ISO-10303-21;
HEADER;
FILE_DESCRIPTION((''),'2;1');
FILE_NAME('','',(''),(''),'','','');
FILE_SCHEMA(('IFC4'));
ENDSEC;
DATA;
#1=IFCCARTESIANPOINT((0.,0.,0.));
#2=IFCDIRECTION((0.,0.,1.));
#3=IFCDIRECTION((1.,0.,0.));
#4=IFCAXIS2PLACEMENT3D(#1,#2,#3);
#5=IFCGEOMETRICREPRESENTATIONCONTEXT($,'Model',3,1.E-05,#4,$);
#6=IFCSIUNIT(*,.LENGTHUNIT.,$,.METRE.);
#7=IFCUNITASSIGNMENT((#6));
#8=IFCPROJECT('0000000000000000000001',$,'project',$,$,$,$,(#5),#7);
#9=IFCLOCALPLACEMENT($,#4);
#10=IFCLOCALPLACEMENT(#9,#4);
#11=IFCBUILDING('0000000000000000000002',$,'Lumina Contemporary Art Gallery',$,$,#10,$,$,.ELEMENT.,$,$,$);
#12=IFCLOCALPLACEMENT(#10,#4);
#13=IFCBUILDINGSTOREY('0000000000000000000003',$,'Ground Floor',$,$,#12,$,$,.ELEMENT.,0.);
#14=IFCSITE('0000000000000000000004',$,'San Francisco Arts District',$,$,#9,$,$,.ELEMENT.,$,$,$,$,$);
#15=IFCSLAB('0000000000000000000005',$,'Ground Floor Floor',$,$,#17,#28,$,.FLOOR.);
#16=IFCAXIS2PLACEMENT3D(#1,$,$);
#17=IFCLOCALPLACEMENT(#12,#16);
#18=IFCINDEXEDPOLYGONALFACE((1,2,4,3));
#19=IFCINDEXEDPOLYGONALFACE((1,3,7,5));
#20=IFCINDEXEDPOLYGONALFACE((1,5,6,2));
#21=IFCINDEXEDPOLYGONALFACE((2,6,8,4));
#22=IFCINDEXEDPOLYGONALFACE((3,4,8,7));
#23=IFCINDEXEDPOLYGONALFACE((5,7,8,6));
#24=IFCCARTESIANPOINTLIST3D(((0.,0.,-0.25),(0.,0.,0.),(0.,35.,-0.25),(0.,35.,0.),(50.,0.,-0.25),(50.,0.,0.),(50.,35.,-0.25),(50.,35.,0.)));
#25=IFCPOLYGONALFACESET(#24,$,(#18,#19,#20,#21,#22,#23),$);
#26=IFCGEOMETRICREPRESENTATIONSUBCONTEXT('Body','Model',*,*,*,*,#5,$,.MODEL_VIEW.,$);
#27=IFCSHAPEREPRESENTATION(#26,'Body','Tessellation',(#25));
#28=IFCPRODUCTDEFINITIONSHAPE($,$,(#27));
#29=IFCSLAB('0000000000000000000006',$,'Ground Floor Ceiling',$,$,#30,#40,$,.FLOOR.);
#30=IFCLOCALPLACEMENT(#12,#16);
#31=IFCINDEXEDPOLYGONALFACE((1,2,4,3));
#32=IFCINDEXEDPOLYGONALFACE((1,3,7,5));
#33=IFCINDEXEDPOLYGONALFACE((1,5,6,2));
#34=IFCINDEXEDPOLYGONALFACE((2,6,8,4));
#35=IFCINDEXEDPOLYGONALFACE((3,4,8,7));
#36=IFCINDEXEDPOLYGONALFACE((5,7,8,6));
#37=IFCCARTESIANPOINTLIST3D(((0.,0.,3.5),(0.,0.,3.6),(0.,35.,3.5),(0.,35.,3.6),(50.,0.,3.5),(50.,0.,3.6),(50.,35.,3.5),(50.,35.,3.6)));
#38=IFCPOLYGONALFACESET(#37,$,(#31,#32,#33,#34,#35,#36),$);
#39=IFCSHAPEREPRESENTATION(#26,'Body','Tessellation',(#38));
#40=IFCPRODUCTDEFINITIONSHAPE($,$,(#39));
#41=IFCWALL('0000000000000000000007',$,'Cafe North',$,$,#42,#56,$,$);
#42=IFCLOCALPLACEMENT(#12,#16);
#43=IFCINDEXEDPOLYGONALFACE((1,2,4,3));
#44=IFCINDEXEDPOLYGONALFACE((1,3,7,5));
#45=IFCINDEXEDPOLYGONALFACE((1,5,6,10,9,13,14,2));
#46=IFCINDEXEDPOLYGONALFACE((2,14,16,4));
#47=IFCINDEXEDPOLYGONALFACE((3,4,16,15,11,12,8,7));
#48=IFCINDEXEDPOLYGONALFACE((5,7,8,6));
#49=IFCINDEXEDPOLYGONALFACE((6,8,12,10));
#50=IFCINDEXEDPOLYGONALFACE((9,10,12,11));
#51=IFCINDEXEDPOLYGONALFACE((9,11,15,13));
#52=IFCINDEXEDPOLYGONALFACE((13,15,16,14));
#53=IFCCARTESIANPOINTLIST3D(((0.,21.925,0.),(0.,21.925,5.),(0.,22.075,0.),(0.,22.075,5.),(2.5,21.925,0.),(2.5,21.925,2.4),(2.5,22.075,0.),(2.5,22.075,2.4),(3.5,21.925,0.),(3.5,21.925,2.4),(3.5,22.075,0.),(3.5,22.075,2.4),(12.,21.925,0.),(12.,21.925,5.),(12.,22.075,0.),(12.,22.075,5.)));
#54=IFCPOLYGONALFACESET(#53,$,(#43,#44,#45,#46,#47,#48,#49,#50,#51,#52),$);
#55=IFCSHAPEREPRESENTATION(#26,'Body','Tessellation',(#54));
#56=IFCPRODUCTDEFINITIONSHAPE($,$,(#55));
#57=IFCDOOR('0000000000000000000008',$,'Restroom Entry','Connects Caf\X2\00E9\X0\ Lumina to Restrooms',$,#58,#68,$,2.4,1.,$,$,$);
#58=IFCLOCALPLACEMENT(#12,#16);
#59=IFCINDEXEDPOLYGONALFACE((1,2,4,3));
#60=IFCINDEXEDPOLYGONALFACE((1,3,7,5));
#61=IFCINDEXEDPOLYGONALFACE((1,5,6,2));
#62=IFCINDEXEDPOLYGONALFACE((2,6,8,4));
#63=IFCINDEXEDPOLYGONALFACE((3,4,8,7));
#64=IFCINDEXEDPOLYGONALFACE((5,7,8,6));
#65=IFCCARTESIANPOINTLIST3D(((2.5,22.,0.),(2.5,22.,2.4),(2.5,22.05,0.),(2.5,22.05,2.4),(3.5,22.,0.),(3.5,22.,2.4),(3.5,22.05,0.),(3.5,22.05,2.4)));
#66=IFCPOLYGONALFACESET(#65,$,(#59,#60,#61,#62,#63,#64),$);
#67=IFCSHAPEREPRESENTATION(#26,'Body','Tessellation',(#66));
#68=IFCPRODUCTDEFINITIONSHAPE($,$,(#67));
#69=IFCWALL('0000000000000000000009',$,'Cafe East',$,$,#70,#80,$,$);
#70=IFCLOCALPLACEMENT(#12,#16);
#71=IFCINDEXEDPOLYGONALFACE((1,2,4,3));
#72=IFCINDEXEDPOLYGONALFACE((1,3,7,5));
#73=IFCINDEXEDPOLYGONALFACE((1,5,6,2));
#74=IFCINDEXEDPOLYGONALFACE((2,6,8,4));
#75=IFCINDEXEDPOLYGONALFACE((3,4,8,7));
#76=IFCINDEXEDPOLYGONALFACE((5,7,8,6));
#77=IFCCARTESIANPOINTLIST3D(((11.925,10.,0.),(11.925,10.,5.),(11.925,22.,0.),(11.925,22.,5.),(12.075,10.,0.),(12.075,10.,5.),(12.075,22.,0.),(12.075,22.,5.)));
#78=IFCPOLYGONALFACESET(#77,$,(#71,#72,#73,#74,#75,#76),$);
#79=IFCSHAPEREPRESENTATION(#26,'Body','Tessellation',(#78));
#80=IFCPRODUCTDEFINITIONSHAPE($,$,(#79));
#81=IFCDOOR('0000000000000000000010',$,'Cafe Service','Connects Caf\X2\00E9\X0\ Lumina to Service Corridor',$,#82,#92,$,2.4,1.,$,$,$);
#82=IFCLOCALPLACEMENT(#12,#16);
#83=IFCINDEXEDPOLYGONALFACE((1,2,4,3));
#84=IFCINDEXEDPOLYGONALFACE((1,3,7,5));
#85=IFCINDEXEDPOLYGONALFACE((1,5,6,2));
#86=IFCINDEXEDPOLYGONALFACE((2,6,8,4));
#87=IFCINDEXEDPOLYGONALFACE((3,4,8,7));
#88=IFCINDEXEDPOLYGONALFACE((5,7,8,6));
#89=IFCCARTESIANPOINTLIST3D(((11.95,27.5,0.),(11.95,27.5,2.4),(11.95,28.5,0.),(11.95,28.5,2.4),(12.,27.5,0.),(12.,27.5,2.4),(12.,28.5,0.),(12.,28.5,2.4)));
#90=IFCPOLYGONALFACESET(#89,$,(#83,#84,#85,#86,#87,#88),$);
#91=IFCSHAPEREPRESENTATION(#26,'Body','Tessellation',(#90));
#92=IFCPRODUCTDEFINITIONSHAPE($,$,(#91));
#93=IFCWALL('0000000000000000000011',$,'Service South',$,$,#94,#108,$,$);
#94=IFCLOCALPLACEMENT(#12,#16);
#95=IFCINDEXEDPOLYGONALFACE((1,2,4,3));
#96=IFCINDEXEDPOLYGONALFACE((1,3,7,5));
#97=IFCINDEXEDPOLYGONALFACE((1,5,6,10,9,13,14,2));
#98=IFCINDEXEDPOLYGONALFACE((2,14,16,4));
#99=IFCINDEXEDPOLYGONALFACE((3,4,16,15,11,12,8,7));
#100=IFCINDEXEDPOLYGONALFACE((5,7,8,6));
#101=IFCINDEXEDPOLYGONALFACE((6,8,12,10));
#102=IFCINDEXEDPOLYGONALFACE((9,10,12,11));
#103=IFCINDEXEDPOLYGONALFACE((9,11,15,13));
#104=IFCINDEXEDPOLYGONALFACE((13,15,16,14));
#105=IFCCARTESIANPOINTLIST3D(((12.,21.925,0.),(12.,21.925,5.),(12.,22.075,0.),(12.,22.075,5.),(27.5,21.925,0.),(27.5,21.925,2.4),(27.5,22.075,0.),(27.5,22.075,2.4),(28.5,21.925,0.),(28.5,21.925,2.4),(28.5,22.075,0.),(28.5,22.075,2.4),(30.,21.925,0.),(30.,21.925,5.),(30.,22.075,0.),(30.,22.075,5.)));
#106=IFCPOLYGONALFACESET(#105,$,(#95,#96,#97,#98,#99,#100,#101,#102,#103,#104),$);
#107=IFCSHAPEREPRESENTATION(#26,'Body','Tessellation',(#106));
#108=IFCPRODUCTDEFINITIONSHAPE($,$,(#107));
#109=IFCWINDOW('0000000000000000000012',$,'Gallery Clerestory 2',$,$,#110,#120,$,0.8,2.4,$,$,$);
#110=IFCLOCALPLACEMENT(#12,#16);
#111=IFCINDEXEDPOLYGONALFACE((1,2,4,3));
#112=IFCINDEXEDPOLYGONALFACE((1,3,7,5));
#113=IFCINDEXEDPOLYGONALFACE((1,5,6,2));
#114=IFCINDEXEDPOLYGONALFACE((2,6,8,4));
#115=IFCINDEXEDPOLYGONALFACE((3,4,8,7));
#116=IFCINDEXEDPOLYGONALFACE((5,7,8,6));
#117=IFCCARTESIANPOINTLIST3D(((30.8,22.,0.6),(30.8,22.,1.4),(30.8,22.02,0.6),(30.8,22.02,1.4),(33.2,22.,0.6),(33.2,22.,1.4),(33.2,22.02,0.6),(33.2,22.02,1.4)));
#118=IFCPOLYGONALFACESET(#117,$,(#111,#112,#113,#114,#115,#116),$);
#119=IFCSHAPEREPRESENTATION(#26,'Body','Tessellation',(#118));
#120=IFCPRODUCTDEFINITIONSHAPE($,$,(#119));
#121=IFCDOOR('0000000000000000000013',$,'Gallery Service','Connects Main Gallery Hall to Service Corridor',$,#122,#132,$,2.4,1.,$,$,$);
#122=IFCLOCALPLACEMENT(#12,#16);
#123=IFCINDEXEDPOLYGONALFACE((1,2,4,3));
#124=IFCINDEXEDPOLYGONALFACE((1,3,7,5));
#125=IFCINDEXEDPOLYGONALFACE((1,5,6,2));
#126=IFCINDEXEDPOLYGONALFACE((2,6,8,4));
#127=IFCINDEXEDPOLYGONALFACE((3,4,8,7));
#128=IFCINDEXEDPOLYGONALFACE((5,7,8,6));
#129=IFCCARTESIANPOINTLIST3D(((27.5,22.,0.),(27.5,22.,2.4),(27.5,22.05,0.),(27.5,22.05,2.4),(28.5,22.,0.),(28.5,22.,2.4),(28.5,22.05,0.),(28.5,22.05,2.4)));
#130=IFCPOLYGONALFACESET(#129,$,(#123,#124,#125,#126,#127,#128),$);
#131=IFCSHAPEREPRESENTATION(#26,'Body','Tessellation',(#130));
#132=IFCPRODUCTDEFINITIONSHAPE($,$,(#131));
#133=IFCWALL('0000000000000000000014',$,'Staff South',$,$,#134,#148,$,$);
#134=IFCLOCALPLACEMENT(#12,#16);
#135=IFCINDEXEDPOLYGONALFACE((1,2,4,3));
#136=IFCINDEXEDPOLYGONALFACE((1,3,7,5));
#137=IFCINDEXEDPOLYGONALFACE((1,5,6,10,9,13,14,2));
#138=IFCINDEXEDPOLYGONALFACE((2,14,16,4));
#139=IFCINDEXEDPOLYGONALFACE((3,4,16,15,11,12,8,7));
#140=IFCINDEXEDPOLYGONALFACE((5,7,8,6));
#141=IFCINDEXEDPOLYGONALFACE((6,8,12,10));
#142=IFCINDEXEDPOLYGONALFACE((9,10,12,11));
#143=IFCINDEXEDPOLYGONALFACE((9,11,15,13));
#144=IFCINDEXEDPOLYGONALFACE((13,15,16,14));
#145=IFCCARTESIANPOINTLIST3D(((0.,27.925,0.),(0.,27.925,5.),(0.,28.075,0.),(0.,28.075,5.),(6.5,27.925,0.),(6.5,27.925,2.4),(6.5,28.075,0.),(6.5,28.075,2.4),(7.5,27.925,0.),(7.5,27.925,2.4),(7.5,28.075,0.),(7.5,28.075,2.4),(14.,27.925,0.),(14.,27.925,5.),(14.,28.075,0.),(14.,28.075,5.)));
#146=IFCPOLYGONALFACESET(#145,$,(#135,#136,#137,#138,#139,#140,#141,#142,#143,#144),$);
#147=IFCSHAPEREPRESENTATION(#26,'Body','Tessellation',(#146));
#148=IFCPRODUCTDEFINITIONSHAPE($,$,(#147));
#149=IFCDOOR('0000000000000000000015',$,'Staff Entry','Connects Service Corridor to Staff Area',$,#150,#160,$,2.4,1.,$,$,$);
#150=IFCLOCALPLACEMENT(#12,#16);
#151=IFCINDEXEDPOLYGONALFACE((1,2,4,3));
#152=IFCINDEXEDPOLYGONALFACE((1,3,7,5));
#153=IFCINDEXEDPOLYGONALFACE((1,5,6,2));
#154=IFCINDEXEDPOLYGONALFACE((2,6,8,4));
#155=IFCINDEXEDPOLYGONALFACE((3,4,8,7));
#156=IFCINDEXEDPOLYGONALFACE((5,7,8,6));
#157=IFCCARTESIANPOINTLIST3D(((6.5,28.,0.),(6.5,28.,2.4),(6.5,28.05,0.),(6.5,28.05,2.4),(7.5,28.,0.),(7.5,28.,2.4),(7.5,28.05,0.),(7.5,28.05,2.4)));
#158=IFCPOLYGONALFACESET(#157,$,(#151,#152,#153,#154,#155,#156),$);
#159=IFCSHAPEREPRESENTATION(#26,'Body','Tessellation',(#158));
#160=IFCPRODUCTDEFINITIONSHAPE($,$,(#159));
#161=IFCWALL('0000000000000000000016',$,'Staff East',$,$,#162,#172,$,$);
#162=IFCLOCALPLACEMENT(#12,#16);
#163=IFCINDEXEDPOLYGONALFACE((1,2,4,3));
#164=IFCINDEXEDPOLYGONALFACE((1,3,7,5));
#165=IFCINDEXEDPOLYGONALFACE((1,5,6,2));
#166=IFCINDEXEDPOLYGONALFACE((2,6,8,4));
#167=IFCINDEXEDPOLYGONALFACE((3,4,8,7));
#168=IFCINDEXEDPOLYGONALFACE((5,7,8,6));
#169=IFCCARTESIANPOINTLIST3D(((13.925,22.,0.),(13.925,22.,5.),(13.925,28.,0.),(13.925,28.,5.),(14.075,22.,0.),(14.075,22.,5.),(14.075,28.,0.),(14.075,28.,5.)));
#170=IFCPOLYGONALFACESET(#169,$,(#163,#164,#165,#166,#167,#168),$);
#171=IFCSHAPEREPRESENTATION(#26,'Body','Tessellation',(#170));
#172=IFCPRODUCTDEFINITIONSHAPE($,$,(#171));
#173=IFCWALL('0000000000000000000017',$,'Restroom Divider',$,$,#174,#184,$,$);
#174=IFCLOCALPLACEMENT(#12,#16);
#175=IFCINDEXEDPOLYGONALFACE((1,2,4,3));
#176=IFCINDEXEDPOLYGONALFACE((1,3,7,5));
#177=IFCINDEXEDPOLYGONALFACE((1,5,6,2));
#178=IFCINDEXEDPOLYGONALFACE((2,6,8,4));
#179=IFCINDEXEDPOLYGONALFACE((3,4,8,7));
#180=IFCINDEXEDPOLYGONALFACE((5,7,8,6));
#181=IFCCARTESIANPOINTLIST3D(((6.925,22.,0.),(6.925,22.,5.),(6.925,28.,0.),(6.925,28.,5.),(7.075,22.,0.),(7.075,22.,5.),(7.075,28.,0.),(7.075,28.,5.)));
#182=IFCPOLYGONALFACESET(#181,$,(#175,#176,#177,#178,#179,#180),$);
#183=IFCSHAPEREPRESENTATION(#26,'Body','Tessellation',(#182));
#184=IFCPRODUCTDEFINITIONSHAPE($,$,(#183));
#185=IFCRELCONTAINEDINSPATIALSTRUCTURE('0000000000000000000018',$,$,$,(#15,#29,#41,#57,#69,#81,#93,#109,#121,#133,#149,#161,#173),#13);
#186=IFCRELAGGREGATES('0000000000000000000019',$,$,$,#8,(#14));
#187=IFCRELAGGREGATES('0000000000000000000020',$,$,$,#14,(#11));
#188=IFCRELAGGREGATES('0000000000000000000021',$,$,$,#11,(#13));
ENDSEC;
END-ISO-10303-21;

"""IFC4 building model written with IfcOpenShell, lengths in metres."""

from ifc_helpers import new_model, si_unit, origin_with_axes, place, context, subcontext, project, spatial, polyline, outline, extrude, element, fill, save


model = new_model("IFC4")

# Units and contexts
model_context = context("Model", 3, precision=1e-05, world=origin_with_axes())
body_context = subcontext(model_context, "Body", "Model", "MODEL_VIEW")
ifc_project = project(units=[si_unit("LENGTHUNIT", "METRE")], contexts=[model_context])

# Site, building, storey
site_placement = place(None, origin_with_axes())
site = spatial("IfcSite", under=ifc_project, at=site_placement, Name="San Francisco Arts District", CompositionType="ELEMENT")
building_placement = place(site_placement, origin_with_axes())
building = spatial("IfcBuilding", under=site, at=building_placement, Name="Lumina Contemporary Art Gallery", CompositionType="ELEMENT")
storey_placement = place(building_placement, origin_with_axes())
storey = spatial("IfcBuildingStorey", under=building, at=storey_placement, Name="Ground Floor", CompositionType="ELEMENT", Elevation=0.0)

# Slabs
slab_1_placement = place(storey_placement, origin_with_axes())
element("IfcSlab", 1, at=slab_1_placement, inside=storey, Name="Ground Floor Floor", PredefinedType="FLOOR", context=body_context, shape_type="SweptSolid", body=[
    extrude(outline(polyline([(0.0, 0.0, -0.25), (50.0, 0.0, -0.25), (50.0, 35.0, -0.25), (0.0, 35.0, -0.25), (0.0, 0.0, -0.25)])), None, (0.0, 0.0, 1.0), 0.25),
])
slab_2_placement = place(storey_placement, origin_with_axes())
element("IfcSlab", 2, at=slab_2_placement, inside=storey, Name="Ground Floor Ceiling", PredefinedType="FLOOR", context=body_context, shape_type="SweptSolid", body=[
    extrude(outline(polyline([(0.0, 0.0, 3.5), (50.0, 0.0, 3.5), (50.0, 35.0, 3.5), (0.0, 35.0, 3.5), (0.0, 0.0, 3.5)])), None, (0.0, 0.0, 1.0), 0.1),
])

# Walls, openings, doors
wall_1_placement = place(storey_placement, origin_with_axes())
wall_1 = element("IfcWall", 3, at=wall_1_placement, inside=storey, Name="Cafe North", context=body_context, shape_type="SweptSolid", body=[
    extrude(outline(polyline([(0.0, 21.925, 0.0), (12.0, 21.925, 0.0), (12.0, 22.075, 0.0), (0.0, 22.075, 0.0), (0.0, 21.925, 0.0)])), None, (0.0, 0.0, 1.0), 5.0),
])
opening_1_placement = place(storey_placement, origin_with_axes())
opening_1 = element("IfcOpeningElement", 4, at=opening_1_placement, inside=storey, cuts=wall_1, context=body_context, shape_type="SweptSolid", body=[
    extrude(outline(polyline([(2.5, 21.85, 0.0), (3.5, 21.85, 0.0), (3.5, 22.15, 0.0), (2.5, 22.15, 0.0), (2.5, 21.85, 0.0)])), None, (0.0, 0.0, 1.0), 2.4),
])
door_1_placement = place(storey_placement, origin_with_axes())
door_1 = element("IfcDoor", 5, at=door_1_placement, inside=storey, Name="Restroom Entry", Description="Connects Café Lumina to Restrooms", OverallHeight=2.4, OverallWidth=1.0, context=body_context, shape_type="SweptSolid", body=[
    extrude(outline(polyline([(2.5, 22.0, 0.0), (3.5, 22.0, 0.0), (3.5, 22.05, 0.0), (2.5, 22.05, 0.0), (2.5, 22.0, 0.0)])), None, (0.0, 0.0, 1.0), 2.4),
])
fill(opening_1, door_1)
wall_2_placement = place(storey_placement, origin_with_axes())
wall_2 = element("IfcWall", 6, at=wall_2_placement, inside=storey, Name="Cafe East", context=body_context, shape_type="SweptSolid", body=[
    extrude(outline(polyline([(12.075, 10.0, 0.0), (12.075, 22.0, 0.0), (11.925, 22.0, 0.0), (11.925, 10.0, 0.0), (12.075, 10.0, 0.0)])), None, (0.0, 0.0, 1.0), 5.0),
])
opening_2_placement = place(storey_placement, origin_with_axes())
opening_2 = element("IfcOpeningElement", 7, at=opening_2_placement, inside=storey, cuts=wall_2, context=body_context, shape_type="SweptSolid", body=[
    extrude(outline(polyline([(12.15, 27.5, 0.0), (12.15, 28.5, 0.0), (11.85, 28.5, 0.0), (11.85, 27.5, 0.0), (12.15, 27.5, 0.0)])), None, (0.0, 0.0, 1.0), 2.4),
])
door_2_placement = place(storey_placement, origin_with_axes())
door_2 = element("IfcDoor", 8, at=door_2_placement, inside=storey, Name="Cafe Service", Description="Connects Café Lumina to Service Corridor", OverallHeight=2.4, OverallWidth=1.0, context=body_context, shape_type="SweptSolid", body=[
    extrude(outline(polyline([(12.0, 27.5, 0.0), (12.0, 28.5, 0.0), (11.95, 28.5, 0.0), (11.95, 27.5, 0.0), (12.0, 27.5, 0.0)])), None, (0.0, 0.0, 1.0), 2.4),
])
fill(opening_2, door_2)

# Wall, openings, window, door
wall_3_placement = place(storey_placement, origin_with_axes())
wall_3 = element("IfcWall", 9, at=wall_3_placement, inside=storey, Name="Service South", context=body_context, shape_type="SweptSolid", body=[
    extrude(outline(polyline([(12.0, 21.925, 0.0), (30.0, 21.925, 0.0), (30.0, 22.075, 0.0), (12.0, 22.075, 0.0), (12.0, 21.925, 0.0)])), None, (0.0, 0.0, 1.0), 5.0),
])
opening_3_placement = place(storey_placement, origin_with_axes())
opening_3 = element("IfcOpeningElement", 10, at=opening_3_placement, inside=storey, cuts=wall_3, context=body_context, shape_type="SweptSolid", body=[
    extrude(outline(polyline([(30.8, 21.85, 0.6), (33.2, 21.85, 0.6), (33.2, 22.15, 0.6), (30.8, 22.15, 0.6), (30.8, 21.85, 0.6)])), None, (0.0, 0.0, 1.0), 0.8),
])
opening_4_placement = place(storey_placement, origin_with_axes())
opening_4 = element("IfcOpeningElement", 11, at=opening_4_placement, inside=storey, cuts=wall_3, context=body_context, shape_type="SweptSolid", body=[
    extrude(outline(polyline([(27.5, 21.85, 0.0), (28.5, 21.85, 0.0), (28.5, 22.15, 0.0), (27.5, 22.15, 0.0), (27.5, 21.85, 0.0)])), None, (0.0, 0.0, 1.0), 2.4),
])
window_placement = place(storey_placement, origin_with_axes())
window = element("IfcWindow", 12, at=window_placement, inside=storey, Name="Gallery Clerestory 2", OverallHeight=0.8, OverallWidth=2.4, context=body_context, shape_type="SweptSolid", body=[
    extrude(outline(polyline([(30.8, 22.0, 0.6), (33.2, 22.0, 0.6), (33.2, 22.02, 0.6), (30.8, 22.02, 0.6), (30.8, 22.0, 0.6)])), None, (0.0, 0.0, 1.0), 0.8),
])
fill(opening_3, window)
door_3_placement = place(storey_placement, origin_with_axes())
door_3 = element("IfcDoor", 13, at=door_3_placement, inside=storey, Name="Gallery Service", Description="Connects Main Gallery Hall to Service Corridor", OverallHeight=2.4, OverallWidth=1.0, context=body_context, shape_type="SweptSolid", body=[
    extrude(outline(polyline([(27.5, 22.0, 0.0), (28.5, 22.0, 0.0), (28.5, 22.05, 0.0), (27.5, 22.05, 0.0), (27.5, 22.0, 0.0)])), None, (0.0, 0.0, 1.0), 2.4),
])
fill(opening_4, door_3)

# Wall, opening, door
wall_4_placement = place(storey_placement, origin_with_axes())
wall_4 = element("IfcWall", 14, at=wall_4_placement, inside=storey, Name="Staff South", context=body_context, shape_type="SweptSolid", body=[
    extrude(outline(polyline([(0.0, 27.925, 0.0), (14.0, 27.925, 0.0), (14.0, 28.075, 0.0), (0.0, 28.075, 0.0), (0.0, 27.925, 0.0)])), None, (0.0, 0.0, 1.0), 5.0),
])
opening_5_placement = place(storey_placement, origin_with_axes())
opening_5 = element("IfcOpeningElement", 15, at=opening_5_placement, inside=storey, cuts=wall_4, context=body_context, shape_type="SweptSolid", body=[
    extrude(outline(polyline([(6.5, 27.85, 0.0), (7.5, 27.85, 0.0), (7.5, 28.15, 0.0), (6.5, 28.15, 0.0), (6.5, 27.85, 0.0)])), None, (0.0, 0.0, 1.0), 2.4),
])
door_4_placement = place(storey_placement, origin_with_axes())
door_4 = element("IfcDoor", 16, at=door_4_placement, inside=storey, Name="Staff Entry", Description="Connects Service Corridor to Staff Area", OverallHeight=2.4, OverallWidth=1.0, context=body_context, shape_type="SweptSolid", body=[
    extrude(outline(polyline([(6.5, 28.0, 0.0), (7.5, 28.0, 0.0), (7.5, 28.05, 0.0), (6.5, 28.05, 0.0), (6.5, 28.0, 0.0)])), None, (0.0, 0.0, 1.0), 2.4),
])
fill(opening_5, door_4)

# Walls
wall_5_placement = place(storey_placement, origin_with_axes())
element("IfcWall", 17, at=wall_5_placement, inside=storey, Name="Staff East", context=body_context, shape_type="SweptSolid", body=[
    extrude(outline(polyline([(14.075, 22.0, 0.0), (14.075, 28.0, 0.0), (13.925, 28.0, 0.0), (13.925, 22.0, 0.0), (14.075, 22.0, 0.0)])), None, (0.0, 0.0, 1.0), 5.0),
])
wall_6_placement = place(storey_placement, origin_with_axes())
element("IfcWall", 18, at=wall_6_placement, inside=storey, Name="Restroom Divider", context=body_context, shape_type="SweptSolid", body=[
    extrude(outline(polyline([(7.075, 22.0, 0.0), (7.075, 28.0, 0.0), (6.925, 28.0, 0.0), (6.925, 22.0, 0.0), (7.075, 22.0, 0.0)])), None, (0.0, 0.0, 1.0), 5.0),
])

save(model, "model.ifc")
